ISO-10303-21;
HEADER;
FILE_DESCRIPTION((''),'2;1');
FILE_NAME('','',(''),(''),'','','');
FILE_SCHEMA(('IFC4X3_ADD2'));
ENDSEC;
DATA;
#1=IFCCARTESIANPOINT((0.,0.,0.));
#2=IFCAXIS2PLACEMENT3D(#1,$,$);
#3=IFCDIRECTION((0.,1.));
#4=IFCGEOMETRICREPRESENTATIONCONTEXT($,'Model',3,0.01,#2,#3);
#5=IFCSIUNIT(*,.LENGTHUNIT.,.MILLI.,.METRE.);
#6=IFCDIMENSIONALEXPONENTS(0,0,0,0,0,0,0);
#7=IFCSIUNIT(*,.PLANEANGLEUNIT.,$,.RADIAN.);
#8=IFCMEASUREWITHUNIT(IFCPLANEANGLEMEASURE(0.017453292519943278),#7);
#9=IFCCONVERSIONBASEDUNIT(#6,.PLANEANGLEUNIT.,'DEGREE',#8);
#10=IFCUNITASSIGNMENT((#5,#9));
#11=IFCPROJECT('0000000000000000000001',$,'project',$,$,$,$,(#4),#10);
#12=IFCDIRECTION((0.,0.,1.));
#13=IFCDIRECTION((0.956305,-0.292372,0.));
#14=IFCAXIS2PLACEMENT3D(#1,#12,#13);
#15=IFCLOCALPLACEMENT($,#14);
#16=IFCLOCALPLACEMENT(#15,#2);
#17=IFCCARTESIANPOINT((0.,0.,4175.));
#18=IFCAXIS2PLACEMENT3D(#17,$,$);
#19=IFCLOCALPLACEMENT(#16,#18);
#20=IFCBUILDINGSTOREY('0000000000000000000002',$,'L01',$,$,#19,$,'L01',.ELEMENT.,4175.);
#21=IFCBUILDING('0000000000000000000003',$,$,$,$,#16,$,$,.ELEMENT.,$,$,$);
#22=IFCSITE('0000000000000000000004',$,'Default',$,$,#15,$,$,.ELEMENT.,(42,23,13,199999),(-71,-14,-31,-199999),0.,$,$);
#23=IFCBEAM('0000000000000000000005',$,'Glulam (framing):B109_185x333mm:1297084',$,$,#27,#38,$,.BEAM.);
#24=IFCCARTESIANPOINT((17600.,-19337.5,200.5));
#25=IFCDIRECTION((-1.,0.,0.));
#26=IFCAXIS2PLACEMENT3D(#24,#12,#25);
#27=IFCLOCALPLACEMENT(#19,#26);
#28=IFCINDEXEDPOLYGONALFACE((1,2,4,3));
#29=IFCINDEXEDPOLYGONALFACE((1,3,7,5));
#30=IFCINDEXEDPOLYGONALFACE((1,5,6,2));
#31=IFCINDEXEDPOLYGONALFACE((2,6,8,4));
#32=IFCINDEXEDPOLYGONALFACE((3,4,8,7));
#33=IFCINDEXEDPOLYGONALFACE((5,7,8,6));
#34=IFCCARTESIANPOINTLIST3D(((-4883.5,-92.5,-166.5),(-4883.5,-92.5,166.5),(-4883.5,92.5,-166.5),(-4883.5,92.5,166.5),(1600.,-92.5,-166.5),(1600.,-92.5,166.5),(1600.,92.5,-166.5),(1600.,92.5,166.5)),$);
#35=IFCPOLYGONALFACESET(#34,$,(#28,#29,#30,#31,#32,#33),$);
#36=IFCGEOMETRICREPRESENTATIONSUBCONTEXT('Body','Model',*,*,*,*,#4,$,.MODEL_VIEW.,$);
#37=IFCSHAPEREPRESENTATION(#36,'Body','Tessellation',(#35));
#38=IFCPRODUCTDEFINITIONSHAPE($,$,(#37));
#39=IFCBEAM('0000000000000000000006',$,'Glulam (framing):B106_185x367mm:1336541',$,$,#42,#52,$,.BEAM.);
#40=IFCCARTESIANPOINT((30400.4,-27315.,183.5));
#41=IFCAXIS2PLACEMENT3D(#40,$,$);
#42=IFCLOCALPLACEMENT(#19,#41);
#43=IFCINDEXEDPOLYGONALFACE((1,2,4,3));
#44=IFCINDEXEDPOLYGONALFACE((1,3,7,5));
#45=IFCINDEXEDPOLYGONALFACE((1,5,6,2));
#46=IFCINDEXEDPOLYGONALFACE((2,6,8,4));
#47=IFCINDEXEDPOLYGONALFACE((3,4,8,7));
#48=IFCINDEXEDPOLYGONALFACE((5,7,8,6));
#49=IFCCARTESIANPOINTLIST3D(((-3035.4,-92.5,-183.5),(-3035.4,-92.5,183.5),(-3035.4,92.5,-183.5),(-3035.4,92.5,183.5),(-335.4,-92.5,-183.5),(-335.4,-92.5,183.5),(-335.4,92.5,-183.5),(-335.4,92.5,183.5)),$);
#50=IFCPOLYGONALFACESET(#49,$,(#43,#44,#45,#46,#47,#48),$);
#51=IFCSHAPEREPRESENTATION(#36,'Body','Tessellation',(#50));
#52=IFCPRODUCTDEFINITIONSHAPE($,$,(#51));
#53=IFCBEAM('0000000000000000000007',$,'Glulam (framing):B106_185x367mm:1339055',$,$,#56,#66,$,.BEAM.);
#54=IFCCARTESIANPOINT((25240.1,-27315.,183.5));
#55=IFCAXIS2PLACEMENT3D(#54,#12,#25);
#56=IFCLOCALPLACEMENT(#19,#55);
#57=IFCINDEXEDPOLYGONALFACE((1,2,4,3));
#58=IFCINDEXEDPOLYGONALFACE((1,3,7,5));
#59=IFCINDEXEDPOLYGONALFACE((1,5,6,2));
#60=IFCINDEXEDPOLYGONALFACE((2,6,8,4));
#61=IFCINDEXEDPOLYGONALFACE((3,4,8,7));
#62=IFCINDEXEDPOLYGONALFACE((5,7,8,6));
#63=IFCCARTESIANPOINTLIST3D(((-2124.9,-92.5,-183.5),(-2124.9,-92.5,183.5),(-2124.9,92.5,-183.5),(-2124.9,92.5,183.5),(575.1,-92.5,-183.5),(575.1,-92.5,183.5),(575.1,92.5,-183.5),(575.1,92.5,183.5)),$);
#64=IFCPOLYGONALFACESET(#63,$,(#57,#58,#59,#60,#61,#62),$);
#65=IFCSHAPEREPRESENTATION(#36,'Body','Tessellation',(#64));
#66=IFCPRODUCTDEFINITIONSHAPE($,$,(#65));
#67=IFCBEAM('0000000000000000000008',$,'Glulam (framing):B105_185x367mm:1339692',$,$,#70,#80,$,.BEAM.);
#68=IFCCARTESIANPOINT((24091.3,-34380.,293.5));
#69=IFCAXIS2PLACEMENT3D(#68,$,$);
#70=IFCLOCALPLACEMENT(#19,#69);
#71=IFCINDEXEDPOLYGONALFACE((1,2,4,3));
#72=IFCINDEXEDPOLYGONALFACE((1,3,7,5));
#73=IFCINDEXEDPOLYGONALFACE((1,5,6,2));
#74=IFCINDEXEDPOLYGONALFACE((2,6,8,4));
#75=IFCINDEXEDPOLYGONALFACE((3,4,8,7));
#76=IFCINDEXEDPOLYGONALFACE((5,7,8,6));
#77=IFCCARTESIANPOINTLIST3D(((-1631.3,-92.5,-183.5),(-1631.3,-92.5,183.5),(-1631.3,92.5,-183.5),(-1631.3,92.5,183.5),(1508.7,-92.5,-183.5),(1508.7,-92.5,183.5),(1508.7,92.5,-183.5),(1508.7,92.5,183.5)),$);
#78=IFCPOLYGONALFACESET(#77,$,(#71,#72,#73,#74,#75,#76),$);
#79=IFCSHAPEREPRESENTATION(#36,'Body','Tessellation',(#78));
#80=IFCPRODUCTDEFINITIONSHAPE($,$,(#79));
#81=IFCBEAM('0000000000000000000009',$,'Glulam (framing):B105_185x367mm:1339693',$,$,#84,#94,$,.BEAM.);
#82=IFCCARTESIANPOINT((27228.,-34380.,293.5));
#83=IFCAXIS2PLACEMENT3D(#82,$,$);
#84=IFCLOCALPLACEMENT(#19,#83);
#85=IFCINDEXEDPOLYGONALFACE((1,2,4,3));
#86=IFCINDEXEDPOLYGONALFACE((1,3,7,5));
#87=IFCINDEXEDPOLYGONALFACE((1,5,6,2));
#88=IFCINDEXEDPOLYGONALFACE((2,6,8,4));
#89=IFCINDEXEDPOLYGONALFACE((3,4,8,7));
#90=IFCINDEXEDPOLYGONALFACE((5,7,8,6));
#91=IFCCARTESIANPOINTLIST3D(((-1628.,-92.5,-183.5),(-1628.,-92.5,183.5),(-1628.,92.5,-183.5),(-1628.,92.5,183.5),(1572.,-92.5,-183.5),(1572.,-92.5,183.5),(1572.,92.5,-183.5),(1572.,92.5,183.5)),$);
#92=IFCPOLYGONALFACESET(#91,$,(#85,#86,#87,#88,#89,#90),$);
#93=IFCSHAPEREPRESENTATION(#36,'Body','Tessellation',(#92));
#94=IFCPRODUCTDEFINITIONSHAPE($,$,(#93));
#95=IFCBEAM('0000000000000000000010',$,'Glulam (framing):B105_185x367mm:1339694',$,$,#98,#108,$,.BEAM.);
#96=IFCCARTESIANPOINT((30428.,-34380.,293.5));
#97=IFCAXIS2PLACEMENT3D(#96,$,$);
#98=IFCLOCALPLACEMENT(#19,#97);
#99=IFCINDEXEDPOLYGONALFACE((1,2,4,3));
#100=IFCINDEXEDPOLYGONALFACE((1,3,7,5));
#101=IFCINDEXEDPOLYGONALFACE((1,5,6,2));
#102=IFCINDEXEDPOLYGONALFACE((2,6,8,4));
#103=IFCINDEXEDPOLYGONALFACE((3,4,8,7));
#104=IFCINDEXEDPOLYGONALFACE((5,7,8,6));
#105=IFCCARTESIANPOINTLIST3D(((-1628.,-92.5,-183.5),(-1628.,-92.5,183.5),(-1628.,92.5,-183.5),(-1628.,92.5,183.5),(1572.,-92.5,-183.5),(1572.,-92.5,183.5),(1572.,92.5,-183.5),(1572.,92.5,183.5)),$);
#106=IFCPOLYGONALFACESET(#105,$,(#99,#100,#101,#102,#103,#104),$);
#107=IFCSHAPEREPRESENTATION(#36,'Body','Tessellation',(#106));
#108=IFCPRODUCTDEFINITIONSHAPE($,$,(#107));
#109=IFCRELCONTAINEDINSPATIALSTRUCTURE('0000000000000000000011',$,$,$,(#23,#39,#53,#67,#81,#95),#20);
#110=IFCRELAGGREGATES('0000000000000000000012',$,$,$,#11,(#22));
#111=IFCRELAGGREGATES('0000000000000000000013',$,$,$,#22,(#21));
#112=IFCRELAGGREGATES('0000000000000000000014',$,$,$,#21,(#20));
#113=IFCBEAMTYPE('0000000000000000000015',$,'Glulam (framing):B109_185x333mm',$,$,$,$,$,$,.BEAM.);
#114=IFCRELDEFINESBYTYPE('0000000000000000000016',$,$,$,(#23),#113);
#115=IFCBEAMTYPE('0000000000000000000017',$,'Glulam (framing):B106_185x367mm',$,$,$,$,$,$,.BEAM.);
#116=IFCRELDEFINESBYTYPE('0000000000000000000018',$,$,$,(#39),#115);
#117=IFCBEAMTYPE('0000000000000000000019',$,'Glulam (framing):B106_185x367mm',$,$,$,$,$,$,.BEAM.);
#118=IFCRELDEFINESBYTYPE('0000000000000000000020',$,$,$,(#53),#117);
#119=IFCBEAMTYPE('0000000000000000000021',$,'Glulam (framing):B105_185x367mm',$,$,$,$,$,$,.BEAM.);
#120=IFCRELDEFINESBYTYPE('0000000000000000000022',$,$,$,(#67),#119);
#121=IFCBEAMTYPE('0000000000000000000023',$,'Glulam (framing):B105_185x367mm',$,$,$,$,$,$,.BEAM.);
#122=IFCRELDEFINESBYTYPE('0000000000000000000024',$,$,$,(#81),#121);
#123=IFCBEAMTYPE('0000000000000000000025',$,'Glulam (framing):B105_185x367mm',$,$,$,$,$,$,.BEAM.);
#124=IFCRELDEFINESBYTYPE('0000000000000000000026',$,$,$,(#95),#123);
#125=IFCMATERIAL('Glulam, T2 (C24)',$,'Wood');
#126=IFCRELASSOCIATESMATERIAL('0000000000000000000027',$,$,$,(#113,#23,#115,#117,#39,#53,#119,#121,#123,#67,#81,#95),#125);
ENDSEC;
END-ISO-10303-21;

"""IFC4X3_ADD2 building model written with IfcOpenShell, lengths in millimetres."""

from ifc_helpers import new_model, entity, si_unit, converted_unit, direction, frame, frame_2d, origin, origin_2d_with_axis, place, context, subcontext, project, spatial, rectangle, extrude, source, transform, mapped, material, material_profile, profile_set, profile_usage, type_object, type_shapes, element, save


model = new_model("IFC4X3_ADD2")

# Units and contexts
model_context = context("Model", 3, precision=0.01, world=origin(), true_north=direction((0.0, 1.0)))
body_context = subcontext(model_context, "Body", "Model", "MODEL_VIEW")
ifc_project = project(units=[si_unit("LENGTHUNIT", "METRE", prefix="MILLI"), converted_unit("PLANEANGLEUNIT", "DEGREE", entity("IfcPlaneAngleMeasure", 0.017453292519943278), si_unit("PLANEANGLEUNIT", "RADIAN"), dimensions=[0, 0, 0, 0, 0, 0, 0])], contexts=[model_context])

# Site, building, storey
site_placement = place(None, frame((0.0, 0.0, 0.0), z_axis=(0.0, 0.0, 1.0), x_axis=(0.956305, -0.292372, 0.0)))
site = spatial("IfcSite", under=ifc_project, at=site_placement, Name="Default", CompositionType="ELEMENT", RefLatitude=(42, 23, 13, 199999), RefLongitude=(-71, -14, -31, -199999), RefElevation=0.0)
building_placement = place(site_placement, origin())
building = spatial("IfcBuilding", under=site, at=building_placement, CompositionType="ELEMENT")
storey_placement = place(building_placement, frame((0.0, 0.0, 4175.0)))
storey = spatial("IfcBuildingStorey", under=building, at=storey_placement, Name="L01", LongName="L01", CompositionType="ELEMENT", Elevation=4175.0)

# Beams
ifc_material_1 = material(Name="Glulam, T2 (C24)", Category="Wood")
ifc_material_profile_1 = material_profile(ifc_material_1, rectangle(XDim=185.0, YDim=3200.0, at=origin_2d_with_axis()), Name="B109_185x333mm")
ifc_profile_set_1 = profile_set([ifc_material_profile_1], Name="B109_185x333mm")
ifc_profile_usage_1 = profile_usage(ifc_profile_set_1, cardinal=8)
beam_type_1 = type_object("IfcBeamType", Name="Glulam (framing):B109_185x333mm", PredefinedType="BEAM", material=ifc_profile_set_1)
shared_shape_1 = source(origin(), body_context, "Body", "SweptSolid", [
    extrude(rectangle(XDim=185.0, YDim=6483.5, at=origin_2d_with_axis()), frame((-1641.7, 0.0, -166.5), z_axis=(0.0, 0.0, 1.0), x_axis=(0.0, 1.0, 0.0)), (0.0, 0.0, 1.0), 333.0),
])
type_shapes(beam_type_1, [shared_shape_1])
beam_1_placement = place(storey_placement, frame((17600.0, -19337.5, 200.5), z_axis=(0.0, 0.0, 1.0), x_axis=(-1.0, 0.0, 0.0)))
element("IfcBeam", 1, at=beam_1_placement, inside=storey, type_object=beam_type_1, material=ifc_profile_usage_1, Name="Glulam (framing):B109_185x333mm:1297084", PredefinedType="BEAM", context=body_context, shape_type="MappedRepresentation", body=[
    mapped(shared_shape_1, transform((0.0, 0.0, 0.0), scale=1.0)),
])
ifc_material_profile_2 = material_profile(ifc_material_1, rectangle(XDim=2161.0, YDim=185.0, at=frame_2d((0.0, 0.0), x_axis=(1.0, 0.0))), Name="B106_185x367mm")
ifc_profile_set_2 = profile_set([ifc_material_profile_2], Name="B106_185x367mm")
ifc_profile_usage_2 = profile_usage(ifc_profile_set_2, cardinal=8)
beam_type_2 = type_object("IfcBeamType", Name="Glulam (framing):B106_185x367mm", PredefinedType="BEAM", material=ifc_profile_set_2)
shared_shape_2 = source(origin(), body_context, "Body", "SweptSolid", [
    extrude(rectangle(XDim=2700.0, YDim=185.0, at=origin_2d_with_axis()), frame((-1685.4, 0.0, -183.5), z_axis=(0.0, 0.0, 1.0), x_axis=(-1.0, 0.0, 0.0)), (0.0, 0.0, 1.0), 367.0),
])
type_shapes(beam_type_2, [shared_shape_2])
beam_2_placement = place(storey_placement, frame((30400.4, -27315.0, 183.5)))
element("IfcBeam", 2, at=beam_2_placement, inside=storey, type_object=beam_type_2, material=ifc_profile_usage_2, Name="Glulam (framing):B106_185x367mm:1336541", PredefinedType="BEAM", context=body_context, shape_type="MappedRepresentation", body=[
    mapped(shared_shape_2, transform((0.0, 0.0, 0.0), scale=1.0)),
])
beam_type_3 = type_object("IfcBeamType", Name="Glulam (framing):B106_185x367mm", PredefinedType="BEAM", material=ifc_profile_set_2)
shared_shape_3 = source(origin(), body_context, "Body", "SweptSolid", [
    extrude(rectangle(XDim=185.0, YDim=2700.0, at=origin_2d_with_axis()), frame((-774.9, 0.0, -183.5), z_axis=(0.0, 0.0, 1.0), x_axis=(0.0, 1.0, 0.0)), (0.0, 0.0, 1.0), 367.0),
])
type_shapes(beam_type_3, [shared_shape_3])
beam_3_placement = place(storey_placement, frame((25240.1, -27315.0, 183.5), z_axis=(0.0, 0.0, 1.0), x_axis=(-1.0, 0.0, 0.0)))
element("IfcBeam", 3, at=beam_3_placement, inside=storey, type_object=beam_type_3, material=ifc_profile_usage_2, Name="Glulam (framing):B106_185x367mm:1339055", PredefinedType="BEAM", context=body_context, shape_type="MappedRepresentation", body=[
    mapped(shared_shape_3, transform((0.0, 0.0, 0.0), scale=1.0)),
])
ifc_material_profile_3 = material_profile(ifc_material_1, rectangle(XDim=3241.9, YDim=185.0, at=origin_2d_with_axis()), Name="B105_185x367mm")
ifc_profile_set_3 = profile_set([ifc_material_profile_3], Name="B105_185x367mm")
ifc_profile_usage_3 = profile_usage(ifc_profile_set_3, cardinal=8)
beam_type_4 = type_object("IfcBeamType", Name="Glulam (framing):B105_185x367mm", PredefinedType="BEAM", material=ifc_profile_set_3)
shared_shape_4 = source(origin(), body_context, "Body", "SweptSolid", [
    extrude(rectangle(XDim=3140.0, YDim=185.0, at=origin_2d_with_axis()), frame((-61.3, 0.0, -183.5), z_axis=(0.0, 0.0, 1.0), x_axis=(-1.0, 0.0, 0.0)), (0.0, 0.0, 1.0), 367.0),
])
type_shapes(beam_type_4, [shared_shape_4])
beam_4_placement = place(storey_placement, frame((24091.3, -34380.0, 293.5)))
element("IfcBeam", 4, at=beam_4_placement, inside=storey, type_object=beam_type_4, material=ifc_profile_usage_3, Name="Glulam (framing):B105_185x367mm:1339692", PredefinedType="BEAM", context=body_context, shape_type="MappedRepresentation", body=[
    mapped(shared_shape_4, transform((0.0, 0.0, 0.0), scale=1.0)),
])
beam_type_5 = type_object("IfcBeamType", Name="Glulam (framing):B105_185x367mm", PredefinedType="BEAM", material=ifc_profile_set_3)
shared_shape_5 = source(origin(), body_context, "Body", "SweptSolid", [
    extrude(rectangle(XDim=3200.0, YDim=185.0, at=origin_2d_with_axis()), frame((-28.0, 0.0, -183.5), z_axis=(0.0, 0.0, 1.0), x_axis=(-1.0, 0.0, 0.0)), (0.0, 0.0, 1.0), 367.0),
])
type_shapes(beam_type_5, [shared_shape_5])
beam_5_placement = place(storey_placement, frame((27228.0, -34380.0, 293.5)))
element("IfcBeam", 5, at=beam_5_placement, inside=storey, type_object=beam_type_5, material=ifc_profile_usage_3, Name="Glulam (framing):B105_185x367mm:1339693", PredefinedType="BEAM", context=body_context, shape_type="MappedRepresentation", body=[
    mapped(shared_shape_5, transform((0.0, 0.0, 0.0), scale=1.0)),
])
beam_type_6 = type_object("IfcBeamType", Name="Glulam (framing):B105_185x367mm", PredefinedType="BEAM", material=ifc_profile_set_3)
shared_shape_6 = source(origin(), body_context, "Body", "SweptSolid", [
    extrude(rectangle(XDim=3200.0, YDim=185.0, at=origin_2d_with_axis()), frame((-28.0, 0.0, -183.5), z_axis=(0.0, 0.0, 1.0), x_axis=(-1.0, 0.0, 0.0)), (0.0, 0.0, 1.0), 367.0),
])
type_shapes(beam_type_6, [shared_shape_6])
beam_6_placement = place(storey_placement, frame((30428.0, -34380.0, 293.5)))
element("IfcBeam", 6, at=beam_6_placement, inside=storey, type_object=beam_type_6, material=ifc_profile_usage_3, Name="Glulam (framing):B105_185x367mm:1339694", PredefinedType="BEAM", context=body_context, shape_type="MappedRepresentation", body=[
    mapped(shared_shape_6, transform((0.0, 0.0, 0.0), scale=1.0)),
])

save(model, "model.ifc")
